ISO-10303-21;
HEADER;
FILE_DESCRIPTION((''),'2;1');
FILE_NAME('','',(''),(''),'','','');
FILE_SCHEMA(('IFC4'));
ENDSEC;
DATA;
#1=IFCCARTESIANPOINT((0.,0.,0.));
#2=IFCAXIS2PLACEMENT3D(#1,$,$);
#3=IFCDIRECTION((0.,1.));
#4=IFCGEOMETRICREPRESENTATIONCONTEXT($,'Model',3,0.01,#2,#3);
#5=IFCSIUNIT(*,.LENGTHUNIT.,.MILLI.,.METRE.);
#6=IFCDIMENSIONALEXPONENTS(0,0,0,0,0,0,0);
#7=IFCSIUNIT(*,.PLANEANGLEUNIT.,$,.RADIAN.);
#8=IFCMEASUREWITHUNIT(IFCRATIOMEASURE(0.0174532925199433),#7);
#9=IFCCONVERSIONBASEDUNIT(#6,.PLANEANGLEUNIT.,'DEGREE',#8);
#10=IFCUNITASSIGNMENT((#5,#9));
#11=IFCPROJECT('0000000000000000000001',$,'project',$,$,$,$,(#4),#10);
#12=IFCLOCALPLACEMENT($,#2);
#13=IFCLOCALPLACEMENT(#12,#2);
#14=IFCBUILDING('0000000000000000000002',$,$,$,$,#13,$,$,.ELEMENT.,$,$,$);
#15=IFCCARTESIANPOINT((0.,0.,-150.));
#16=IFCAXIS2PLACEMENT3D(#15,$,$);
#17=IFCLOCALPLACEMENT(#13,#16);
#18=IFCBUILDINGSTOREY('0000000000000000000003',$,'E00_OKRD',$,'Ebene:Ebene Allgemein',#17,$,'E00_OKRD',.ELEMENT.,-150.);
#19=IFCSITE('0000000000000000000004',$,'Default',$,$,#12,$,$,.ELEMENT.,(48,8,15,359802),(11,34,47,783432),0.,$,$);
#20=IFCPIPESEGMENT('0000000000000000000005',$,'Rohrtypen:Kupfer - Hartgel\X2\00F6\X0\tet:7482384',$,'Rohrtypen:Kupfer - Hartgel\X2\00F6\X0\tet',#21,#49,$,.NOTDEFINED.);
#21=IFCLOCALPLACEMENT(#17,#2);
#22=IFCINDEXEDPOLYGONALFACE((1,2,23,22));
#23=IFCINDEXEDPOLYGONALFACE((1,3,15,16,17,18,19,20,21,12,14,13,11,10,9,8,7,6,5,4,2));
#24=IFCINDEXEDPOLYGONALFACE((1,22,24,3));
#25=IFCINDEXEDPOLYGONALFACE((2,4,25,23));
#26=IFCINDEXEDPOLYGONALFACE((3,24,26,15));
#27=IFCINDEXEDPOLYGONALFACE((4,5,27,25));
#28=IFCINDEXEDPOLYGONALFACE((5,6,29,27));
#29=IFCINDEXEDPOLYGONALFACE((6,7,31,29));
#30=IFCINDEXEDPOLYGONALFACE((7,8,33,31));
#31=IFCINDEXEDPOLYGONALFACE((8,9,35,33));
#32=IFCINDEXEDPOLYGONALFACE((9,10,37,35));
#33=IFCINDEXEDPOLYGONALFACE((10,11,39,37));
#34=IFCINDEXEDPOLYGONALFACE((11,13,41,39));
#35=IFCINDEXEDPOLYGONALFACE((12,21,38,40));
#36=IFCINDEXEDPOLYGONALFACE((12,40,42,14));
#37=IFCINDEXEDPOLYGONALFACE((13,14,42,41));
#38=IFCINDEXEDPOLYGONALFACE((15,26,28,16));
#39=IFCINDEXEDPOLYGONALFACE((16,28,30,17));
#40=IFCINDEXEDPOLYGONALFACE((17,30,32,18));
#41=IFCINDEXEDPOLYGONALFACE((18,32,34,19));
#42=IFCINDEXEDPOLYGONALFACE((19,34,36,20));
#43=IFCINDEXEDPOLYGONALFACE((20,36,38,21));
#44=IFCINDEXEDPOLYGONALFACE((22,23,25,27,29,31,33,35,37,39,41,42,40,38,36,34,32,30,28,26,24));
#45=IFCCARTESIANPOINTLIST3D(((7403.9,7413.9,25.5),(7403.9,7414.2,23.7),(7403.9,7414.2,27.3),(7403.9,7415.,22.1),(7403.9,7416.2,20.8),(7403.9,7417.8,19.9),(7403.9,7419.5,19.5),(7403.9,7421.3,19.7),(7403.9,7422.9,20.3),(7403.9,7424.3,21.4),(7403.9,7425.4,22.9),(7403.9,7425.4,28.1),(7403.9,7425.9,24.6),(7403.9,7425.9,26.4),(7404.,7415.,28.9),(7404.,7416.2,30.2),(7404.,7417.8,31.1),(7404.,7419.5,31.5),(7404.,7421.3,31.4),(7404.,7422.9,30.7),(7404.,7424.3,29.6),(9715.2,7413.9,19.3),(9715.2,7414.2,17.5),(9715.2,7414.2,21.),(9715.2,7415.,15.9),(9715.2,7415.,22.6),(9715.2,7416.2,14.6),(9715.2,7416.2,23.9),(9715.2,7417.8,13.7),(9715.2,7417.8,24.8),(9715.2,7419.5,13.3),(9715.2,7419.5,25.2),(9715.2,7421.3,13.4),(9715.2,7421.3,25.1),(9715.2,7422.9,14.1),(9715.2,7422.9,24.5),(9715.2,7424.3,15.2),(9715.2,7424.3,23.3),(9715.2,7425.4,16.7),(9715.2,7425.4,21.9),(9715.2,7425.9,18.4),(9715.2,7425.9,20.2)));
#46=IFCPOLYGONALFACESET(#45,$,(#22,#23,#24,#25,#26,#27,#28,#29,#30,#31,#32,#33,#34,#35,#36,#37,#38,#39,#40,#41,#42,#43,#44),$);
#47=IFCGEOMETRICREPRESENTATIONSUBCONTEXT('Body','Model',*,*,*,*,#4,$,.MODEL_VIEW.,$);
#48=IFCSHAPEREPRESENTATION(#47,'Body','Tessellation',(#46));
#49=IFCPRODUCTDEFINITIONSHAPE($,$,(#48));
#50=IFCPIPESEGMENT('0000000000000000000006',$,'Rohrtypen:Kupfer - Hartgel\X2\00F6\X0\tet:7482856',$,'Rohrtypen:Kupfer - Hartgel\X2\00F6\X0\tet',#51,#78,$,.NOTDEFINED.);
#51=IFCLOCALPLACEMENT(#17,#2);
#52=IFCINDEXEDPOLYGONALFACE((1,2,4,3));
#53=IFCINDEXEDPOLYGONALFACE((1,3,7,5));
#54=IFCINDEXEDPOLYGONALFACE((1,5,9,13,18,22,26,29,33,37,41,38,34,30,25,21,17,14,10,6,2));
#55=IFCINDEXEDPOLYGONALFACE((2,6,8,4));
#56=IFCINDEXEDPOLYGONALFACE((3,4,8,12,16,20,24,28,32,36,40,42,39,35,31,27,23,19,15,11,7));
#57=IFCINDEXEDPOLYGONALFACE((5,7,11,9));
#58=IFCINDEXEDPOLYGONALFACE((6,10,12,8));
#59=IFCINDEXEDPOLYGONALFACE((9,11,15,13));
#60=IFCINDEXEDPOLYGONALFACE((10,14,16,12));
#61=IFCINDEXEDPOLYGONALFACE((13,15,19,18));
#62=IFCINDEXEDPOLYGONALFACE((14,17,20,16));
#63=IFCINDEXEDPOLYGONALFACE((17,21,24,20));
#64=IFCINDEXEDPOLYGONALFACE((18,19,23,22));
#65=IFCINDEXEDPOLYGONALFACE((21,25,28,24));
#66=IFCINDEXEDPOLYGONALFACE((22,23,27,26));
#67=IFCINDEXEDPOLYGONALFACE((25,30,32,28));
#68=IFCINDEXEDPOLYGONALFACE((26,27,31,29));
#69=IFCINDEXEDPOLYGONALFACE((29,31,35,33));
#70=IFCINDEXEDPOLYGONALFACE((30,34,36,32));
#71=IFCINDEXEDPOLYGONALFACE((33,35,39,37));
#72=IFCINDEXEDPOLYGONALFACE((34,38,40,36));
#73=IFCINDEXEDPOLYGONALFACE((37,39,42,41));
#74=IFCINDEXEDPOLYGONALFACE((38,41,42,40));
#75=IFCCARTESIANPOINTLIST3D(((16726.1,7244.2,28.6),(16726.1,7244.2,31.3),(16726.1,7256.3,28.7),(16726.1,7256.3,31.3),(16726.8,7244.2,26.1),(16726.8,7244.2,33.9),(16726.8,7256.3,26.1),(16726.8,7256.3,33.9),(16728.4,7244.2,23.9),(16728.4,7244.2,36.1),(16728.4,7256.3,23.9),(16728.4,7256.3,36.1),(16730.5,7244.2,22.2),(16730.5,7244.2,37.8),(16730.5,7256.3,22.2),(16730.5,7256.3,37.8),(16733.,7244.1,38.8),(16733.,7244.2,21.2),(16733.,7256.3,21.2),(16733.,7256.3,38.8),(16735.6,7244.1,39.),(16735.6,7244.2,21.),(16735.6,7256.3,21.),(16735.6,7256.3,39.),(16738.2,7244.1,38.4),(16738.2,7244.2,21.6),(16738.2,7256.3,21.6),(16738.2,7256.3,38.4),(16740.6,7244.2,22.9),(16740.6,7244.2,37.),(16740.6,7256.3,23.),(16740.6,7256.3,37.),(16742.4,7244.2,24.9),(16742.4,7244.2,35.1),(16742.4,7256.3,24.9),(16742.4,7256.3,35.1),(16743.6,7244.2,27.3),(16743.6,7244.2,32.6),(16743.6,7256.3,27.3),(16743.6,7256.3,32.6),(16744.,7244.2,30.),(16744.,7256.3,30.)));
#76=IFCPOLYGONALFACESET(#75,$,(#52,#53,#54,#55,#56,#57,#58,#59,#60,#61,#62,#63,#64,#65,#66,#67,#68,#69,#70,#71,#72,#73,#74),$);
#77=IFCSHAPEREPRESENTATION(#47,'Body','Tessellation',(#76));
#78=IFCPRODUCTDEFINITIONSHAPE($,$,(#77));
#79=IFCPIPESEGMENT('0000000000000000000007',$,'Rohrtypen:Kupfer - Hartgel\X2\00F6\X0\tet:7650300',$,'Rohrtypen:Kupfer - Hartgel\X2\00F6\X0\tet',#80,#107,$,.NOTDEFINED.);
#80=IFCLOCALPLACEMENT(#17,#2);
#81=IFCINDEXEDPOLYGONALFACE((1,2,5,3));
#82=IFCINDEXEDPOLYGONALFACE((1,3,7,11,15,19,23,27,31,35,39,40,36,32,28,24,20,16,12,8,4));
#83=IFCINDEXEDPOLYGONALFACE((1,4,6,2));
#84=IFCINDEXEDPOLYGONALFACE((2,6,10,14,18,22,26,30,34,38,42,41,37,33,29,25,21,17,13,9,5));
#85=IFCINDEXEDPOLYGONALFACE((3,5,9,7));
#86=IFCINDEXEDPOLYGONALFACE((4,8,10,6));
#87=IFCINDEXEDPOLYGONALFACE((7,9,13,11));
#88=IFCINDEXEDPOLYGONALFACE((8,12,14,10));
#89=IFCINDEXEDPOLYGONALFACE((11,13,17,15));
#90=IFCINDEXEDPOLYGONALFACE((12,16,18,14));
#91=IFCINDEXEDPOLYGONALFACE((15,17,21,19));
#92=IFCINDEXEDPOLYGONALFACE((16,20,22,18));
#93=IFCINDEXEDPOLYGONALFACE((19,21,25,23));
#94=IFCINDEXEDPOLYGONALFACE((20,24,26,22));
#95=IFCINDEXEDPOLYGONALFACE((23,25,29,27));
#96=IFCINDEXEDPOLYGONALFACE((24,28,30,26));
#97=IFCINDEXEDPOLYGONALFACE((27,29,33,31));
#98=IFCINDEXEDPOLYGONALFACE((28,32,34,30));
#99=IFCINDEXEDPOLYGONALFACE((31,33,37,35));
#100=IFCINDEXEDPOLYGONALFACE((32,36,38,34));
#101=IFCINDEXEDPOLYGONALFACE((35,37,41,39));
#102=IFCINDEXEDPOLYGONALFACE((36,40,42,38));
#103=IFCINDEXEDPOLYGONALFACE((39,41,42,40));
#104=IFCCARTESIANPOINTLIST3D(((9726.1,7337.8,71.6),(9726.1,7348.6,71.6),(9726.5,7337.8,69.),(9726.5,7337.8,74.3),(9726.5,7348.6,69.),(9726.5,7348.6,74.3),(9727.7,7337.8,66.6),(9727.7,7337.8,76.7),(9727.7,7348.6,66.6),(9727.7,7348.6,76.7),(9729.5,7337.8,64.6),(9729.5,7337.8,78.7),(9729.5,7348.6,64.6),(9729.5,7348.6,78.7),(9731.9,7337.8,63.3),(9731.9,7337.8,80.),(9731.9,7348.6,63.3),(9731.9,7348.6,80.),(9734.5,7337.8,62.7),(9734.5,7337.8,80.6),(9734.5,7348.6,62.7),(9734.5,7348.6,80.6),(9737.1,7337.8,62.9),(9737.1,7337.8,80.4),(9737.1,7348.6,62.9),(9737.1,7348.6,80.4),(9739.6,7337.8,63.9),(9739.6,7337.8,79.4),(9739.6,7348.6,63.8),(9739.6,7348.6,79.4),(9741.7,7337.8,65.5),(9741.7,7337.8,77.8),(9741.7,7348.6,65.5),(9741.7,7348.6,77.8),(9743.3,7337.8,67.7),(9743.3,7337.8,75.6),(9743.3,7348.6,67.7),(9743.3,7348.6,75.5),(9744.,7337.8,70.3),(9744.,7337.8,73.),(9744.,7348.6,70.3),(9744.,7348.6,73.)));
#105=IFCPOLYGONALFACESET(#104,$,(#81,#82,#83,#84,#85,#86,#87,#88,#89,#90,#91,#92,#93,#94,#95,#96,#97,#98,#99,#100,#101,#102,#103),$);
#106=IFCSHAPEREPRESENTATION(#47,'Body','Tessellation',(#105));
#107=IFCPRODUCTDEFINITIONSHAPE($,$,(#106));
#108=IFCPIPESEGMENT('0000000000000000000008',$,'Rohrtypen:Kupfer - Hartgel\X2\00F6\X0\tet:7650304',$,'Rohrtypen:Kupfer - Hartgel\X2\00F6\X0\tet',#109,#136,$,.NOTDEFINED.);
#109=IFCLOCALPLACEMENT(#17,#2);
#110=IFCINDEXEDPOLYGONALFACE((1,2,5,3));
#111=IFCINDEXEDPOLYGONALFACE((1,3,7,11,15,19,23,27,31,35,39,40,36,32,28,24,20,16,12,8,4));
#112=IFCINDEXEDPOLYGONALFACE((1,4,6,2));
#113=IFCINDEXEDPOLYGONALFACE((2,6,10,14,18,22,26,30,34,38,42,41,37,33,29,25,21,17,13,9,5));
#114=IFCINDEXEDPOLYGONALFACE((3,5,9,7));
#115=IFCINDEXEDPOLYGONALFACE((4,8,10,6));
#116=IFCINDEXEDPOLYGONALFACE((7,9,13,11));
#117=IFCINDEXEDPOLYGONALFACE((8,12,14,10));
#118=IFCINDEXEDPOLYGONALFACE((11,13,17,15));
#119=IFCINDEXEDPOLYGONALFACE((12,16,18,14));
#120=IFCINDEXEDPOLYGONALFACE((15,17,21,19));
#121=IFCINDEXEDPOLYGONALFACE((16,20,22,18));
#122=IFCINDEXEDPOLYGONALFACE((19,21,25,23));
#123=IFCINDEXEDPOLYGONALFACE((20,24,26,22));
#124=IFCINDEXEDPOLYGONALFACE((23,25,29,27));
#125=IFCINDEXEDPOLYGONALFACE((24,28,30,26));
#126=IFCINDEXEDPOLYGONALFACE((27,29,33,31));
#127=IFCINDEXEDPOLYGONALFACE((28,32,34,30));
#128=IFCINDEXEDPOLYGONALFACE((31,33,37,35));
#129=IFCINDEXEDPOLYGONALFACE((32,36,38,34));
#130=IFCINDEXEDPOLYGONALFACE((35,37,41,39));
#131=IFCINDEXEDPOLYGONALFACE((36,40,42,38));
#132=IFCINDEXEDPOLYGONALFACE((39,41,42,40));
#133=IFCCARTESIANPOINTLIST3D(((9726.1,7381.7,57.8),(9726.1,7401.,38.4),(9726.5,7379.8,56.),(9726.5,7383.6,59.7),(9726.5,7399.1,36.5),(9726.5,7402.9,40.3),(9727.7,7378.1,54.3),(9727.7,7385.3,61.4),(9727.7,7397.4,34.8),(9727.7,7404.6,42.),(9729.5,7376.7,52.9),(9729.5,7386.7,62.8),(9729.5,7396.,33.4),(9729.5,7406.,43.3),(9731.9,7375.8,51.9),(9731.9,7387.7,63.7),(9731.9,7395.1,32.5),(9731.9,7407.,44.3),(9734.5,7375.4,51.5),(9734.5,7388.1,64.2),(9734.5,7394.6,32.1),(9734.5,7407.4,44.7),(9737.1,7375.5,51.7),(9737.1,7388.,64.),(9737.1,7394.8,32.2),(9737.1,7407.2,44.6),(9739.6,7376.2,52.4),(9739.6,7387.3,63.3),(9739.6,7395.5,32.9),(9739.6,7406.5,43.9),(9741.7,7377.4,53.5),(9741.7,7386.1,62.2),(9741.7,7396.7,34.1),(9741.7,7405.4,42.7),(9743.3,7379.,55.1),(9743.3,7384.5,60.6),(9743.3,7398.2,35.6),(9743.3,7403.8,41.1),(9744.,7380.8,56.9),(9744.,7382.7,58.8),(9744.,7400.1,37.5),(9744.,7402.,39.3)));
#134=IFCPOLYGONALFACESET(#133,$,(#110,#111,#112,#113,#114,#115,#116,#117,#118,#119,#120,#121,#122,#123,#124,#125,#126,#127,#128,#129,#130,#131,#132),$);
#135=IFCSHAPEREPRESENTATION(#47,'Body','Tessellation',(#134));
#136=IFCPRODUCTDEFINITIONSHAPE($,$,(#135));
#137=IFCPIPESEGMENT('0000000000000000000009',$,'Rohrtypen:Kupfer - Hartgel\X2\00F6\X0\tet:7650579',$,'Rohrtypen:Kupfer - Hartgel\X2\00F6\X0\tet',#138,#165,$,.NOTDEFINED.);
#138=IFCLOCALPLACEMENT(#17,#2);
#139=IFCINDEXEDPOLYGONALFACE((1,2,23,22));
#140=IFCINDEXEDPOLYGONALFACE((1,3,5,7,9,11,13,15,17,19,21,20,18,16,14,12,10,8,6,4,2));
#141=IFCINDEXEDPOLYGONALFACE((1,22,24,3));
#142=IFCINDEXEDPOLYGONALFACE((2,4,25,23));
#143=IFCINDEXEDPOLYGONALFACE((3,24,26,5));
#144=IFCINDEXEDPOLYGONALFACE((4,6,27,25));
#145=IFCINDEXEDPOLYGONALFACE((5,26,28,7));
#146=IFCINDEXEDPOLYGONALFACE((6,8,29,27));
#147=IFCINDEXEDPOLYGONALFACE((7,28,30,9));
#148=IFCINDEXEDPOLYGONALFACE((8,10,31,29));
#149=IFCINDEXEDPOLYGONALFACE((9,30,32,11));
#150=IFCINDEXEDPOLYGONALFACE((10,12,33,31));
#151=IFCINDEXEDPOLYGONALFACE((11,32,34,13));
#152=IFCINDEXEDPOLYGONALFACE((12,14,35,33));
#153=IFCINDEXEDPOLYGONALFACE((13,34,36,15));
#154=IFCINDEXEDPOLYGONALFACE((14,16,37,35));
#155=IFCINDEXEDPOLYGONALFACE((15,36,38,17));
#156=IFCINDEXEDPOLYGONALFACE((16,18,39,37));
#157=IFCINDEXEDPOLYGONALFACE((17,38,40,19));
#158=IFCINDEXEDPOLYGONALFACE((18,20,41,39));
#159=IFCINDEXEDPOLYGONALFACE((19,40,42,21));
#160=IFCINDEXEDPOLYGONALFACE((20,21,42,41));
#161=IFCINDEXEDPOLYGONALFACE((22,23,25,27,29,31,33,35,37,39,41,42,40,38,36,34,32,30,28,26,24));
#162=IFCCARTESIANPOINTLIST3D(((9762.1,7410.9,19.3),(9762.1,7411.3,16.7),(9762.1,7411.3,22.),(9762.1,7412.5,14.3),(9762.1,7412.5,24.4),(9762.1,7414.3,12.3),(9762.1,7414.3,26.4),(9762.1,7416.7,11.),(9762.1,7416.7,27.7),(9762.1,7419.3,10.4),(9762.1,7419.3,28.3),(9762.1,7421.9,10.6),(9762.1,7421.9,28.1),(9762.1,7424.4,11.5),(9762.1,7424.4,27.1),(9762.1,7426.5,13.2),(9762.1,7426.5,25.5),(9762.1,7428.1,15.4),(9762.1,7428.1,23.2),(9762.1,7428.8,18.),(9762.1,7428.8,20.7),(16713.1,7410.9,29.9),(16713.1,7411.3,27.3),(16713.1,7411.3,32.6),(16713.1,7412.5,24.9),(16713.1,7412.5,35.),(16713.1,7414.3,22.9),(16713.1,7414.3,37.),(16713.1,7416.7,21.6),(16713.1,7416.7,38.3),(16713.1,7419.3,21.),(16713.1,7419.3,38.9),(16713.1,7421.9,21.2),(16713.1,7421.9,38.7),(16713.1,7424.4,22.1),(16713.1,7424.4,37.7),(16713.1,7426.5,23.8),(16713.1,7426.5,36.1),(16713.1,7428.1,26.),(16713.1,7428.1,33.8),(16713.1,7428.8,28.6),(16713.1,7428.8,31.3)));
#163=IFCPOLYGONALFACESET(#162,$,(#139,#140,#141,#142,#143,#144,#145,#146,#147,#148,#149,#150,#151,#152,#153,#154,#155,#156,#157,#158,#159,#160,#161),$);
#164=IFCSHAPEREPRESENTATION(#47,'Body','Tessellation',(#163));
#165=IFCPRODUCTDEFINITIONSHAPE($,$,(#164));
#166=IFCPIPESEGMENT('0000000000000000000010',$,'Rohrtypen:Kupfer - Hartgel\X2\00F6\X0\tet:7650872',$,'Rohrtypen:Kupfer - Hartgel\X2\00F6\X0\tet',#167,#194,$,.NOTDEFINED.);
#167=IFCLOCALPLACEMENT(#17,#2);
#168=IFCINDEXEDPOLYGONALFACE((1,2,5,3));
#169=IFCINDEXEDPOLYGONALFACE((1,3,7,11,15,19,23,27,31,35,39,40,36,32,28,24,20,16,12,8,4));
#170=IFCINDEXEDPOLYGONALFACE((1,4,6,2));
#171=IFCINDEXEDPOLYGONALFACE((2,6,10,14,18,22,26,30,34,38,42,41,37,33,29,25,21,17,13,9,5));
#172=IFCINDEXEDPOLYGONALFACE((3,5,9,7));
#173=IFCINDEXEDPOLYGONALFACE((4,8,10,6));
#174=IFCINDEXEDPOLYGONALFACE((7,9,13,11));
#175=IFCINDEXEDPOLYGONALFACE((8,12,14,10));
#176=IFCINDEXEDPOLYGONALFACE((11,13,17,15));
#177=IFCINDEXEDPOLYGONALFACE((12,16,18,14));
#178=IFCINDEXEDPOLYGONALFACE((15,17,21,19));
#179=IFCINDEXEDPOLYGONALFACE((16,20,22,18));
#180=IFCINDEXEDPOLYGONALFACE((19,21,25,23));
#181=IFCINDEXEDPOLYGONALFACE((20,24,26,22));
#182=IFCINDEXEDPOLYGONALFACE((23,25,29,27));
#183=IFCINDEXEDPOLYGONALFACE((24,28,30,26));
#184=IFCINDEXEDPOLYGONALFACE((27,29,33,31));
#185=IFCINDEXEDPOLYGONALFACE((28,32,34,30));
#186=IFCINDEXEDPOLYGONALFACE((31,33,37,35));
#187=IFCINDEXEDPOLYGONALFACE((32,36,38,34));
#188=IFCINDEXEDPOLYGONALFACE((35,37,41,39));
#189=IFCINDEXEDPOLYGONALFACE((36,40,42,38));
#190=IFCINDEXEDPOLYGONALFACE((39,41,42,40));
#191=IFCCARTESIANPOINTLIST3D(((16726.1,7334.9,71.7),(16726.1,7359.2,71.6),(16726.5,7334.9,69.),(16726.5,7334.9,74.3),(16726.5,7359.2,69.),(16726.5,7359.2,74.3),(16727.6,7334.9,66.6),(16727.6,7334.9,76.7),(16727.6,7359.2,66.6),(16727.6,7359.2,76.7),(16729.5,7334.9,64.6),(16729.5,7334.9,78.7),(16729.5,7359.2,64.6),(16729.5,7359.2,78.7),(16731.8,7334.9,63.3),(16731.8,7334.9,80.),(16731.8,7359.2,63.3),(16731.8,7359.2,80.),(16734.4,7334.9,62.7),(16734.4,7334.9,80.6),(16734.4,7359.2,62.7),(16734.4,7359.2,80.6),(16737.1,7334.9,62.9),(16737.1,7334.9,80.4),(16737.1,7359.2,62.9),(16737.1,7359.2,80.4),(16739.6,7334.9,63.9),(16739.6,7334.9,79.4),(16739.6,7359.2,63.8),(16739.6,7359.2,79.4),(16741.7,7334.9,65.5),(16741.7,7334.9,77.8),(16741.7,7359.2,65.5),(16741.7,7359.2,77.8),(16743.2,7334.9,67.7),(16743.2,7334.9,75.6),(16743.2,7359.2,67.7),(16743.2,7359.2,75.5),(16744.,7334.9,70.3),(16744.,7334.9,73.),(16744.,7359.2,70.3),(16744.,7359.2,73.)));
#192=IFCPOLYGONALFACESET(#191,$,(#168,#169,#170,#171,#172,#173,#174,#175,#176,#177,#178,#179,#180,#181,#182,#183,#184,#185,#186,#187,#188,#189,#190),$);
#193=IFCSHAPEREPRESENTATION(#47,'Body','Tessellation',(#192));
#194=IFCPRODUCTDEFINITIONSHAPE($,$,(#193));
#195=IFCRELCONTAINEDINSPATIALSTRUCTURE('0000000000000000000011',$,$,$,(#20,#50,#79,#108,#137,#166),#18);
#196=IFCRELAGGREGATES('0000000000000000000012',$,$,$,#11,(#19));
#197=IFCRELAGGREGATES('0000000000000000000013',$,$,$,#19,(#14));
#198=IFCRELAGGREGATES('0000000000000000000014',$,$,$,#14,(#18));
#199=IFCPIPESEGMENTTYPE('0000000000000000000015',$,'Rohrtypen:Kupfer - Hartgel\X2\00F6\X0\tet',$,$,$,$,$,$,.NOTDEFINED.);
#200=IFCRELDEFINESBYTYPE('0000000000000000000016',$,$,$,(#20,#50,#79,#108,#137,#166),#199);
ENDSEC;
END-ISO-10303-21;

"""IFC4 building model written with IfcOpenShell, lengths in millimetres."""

from ifc_helpers import new_model, entity, si_unit, converted_unit, direction, frame, frame_2d, origin, origin_2d_with_axis, place, context, subcontext, project, spatial, circle, extrude, type_object, element, save


model = new_model("IFC4")

# Units and contexts
model_context = context("Model", 3, precision=0.01, world=origin(), true_north=direction((0.0, 1.0)))
body_context = subcontext(model_context, "Body", "Model", "MODEL_VIEW")
ifc_project = project(units=[si_unit("LENGTHUNIT", "METRE", prefix="MILLI"), converted_unit("PLANEANGLEUNIT", "DEGREE", entity("IfcRatioMeasure", 0.0174532925199433), si_unit("PLANEANGLEUNIT", "RADIAN"), dimensions=[0, 0, 0, 0, 0, 0, 0])], contexts=[model_context])

# Site, building, storey
site_placement = place(None, origin())
site = spatial("IfcSite", under=ifc_project, at=site_placement, Name="Default", CompositionType="ELEMENT", RefLatitude=(48, 8, 15, 359802), RefLongitude=(11, 34, 47, 783432), RefElevation=0.0)
building_placement = place(site_placement, origin())
building = spatial("IfcBuilding", under=site, at=building_placement, CompositionType="ELEMENT")
storey_placement = place(building_placement, frame((0.0, 0.0, -150.0)))
storey = spatial("IfcBuildingStorey", under=building, at=storey_placement, Name="E00_OKRD", ObjectType="Ebene:Ebene Allgemein", LongName="E00_OKRD", CompositionType="ELEMENT", Elevation=-150.0)

# Pipe segments
pipe_segment_type = type_object("IfcPipeSegmentType", Name="Rohrtypen:Kupfer - Hartgelötet", PredefinedType="NOTDEFINED")
pipe_segment_1_placement = place(storey_placement, frame((7403.9, 7412.3, 11.7)))
element("IfcPipeSegment", 1, at=pipe_segment_1_placement, inside=storey, type_object=pipe_segment_type, Name="Rohrtypen:Kupfer - Hartgelötet:7482384", ObjectType="Rohrtypen:Kupfer - Hartgelötet", PredefinedType="NOTDEFINED", context=body_context, shape_type="SweptSolid", body=[
    extrude(circle(Radius=6.0, at=origin_2d_with_axis()), frame((0.0, 7.6, 13.9), z_axis=(0.999996, 0.0, -0.002708), x_axis=(0.0, -1.0, 0.0)), (0.0, 0.0, 1.0), 2311.2),
])
pipe_segment_2_placement = place(storey_placement, frame((16724.4, 7244.1, 19.4)))
element("IfcPipeSegment", 2, at=pipe_segment_2_placement, inside=storey, type_object=pipe_segment_type, Name="Rohrtypen:Kupfer - Hartgelötet:7482856", ObjectType="Rohrtypen:Kupfer - Hartgelötet", PredefinedType="NOTDEFINED", context=body_context, shape_type="SweptSolid", body=[
    extrude(circle(Radius=9.0, at=frame_2d((0.0, 0.0), x_axis=(1.0, 0.0))), frame((10.6, 0.0, 10.6), z_axis=(0.0, 1.0, 0.000964), x_axis=(1.0, 0.0, 0.0)), (0.0, 0.0, 1.0), 12.1),
])
pipe_segment_3_placement = place(storey_placement, frame((9724.6, 7337.8, 61.0)))
element("IfcPipeSegment", 3, at=pipe_segment_3_placement, inside=storey, type_object=pipe_segment_type, Name="Rohrtypen:Kupfer - Hartgelötet:7650300", ObjectType="Rohrtypen:Kupfer - Hartgelötet", PredefinedType="NOTDEFINED", context=body_context, shape_type="SweptSolid", body=[
    extrude(circle(Radius=9.0, at=origin_2d_with_axis()), frame((10.6, 0.0, 10.6), z_axis=(0.0, 1.0, -0.000282), x_axis=(-1.0, 0.0, 0.0)), (0.0, 0.0, 1.0), 10.9),
])
pipe_segment_4_placement = place(storey_placement, frame((9724.6, 7373.7, 30.5)))
element("IfcPipeSegment", 4, at=pipe_segment_4_placement, inside=storey, type_object=pipe_segment_type, Name="Rohrtypen:Kupfer - Hartgelötet:7650304", ObjectType="Rohrtypen:Kupfer - Hartgelötet", PredefinedType="NOTDEFINED", context=body_context, shape_type="SweptSolid", body=[
    extrude(circle(Radius=9.0, at=frame_2d((0.0, 0.0), x_axis=(1.0, 0.0))), frame((10.6, 27.3, 7.9), z_axis=(0.0, -0.70394, 0.71026), x_axis=(-1.0, 0.0, 0.0)), (0.0, 0.0, 1.0), 27.4),
])
pipe_segment_5_placement = place(storey_placement, frame((9762.1, 7409.3, 8.7)))
element("IfcPipeSegment", 5, at=pipe_segment_5_placement, inside=storey, type_object=pipe_segment_type, Name="Rohrtypen:Kupfer - Hartgelötet:7650579", ObjectType="Rohrtypen:Kupfer - Hartgelötet", PredefinedType="NOTDEFINED", context=body_context, shape_type="SweptSolid", body=[
    extrude(circle(Radius=9.0, at=frame_2d((0.0, 0.0), x_axis=(1.0, 0.0))), frame((0.0, 10.6, 10.6), z_axis=(0.999999, 0.0, 0.001525), x_axis=(0.0, -1.0, 0.0)), (0.0, 0.0, 1.0), 6951.0),
])
pipe_segment_6_placement = place(storey_placement, frame((16724.5, 7334.9, 61.0)))
element("IfcPipeSegment", 6, at=pipe_segment_6_placement, inside=storey, type_object=pipe_segment_type, Name="Rohrtypen:Kupfer - Hartgelötet:7650872", ObjectType="Rohrtypen:Kupfer - Hartgelötet", PredefinedType="NOTDEFINED", context=body_context, shape_type="SweptSolid", body=[
    extrude(circle(Radius=9.0, at=origin_2d_with_axis()), frame((10.6, 0.0, 10.6), z_axis=(0.000802, 1.0, -0.000354), x_axis=(-1.0, 0.000802, 0.0)), (0.0, 0.0, 1.0), 24.4),
])

save(model, "model.ifc")
